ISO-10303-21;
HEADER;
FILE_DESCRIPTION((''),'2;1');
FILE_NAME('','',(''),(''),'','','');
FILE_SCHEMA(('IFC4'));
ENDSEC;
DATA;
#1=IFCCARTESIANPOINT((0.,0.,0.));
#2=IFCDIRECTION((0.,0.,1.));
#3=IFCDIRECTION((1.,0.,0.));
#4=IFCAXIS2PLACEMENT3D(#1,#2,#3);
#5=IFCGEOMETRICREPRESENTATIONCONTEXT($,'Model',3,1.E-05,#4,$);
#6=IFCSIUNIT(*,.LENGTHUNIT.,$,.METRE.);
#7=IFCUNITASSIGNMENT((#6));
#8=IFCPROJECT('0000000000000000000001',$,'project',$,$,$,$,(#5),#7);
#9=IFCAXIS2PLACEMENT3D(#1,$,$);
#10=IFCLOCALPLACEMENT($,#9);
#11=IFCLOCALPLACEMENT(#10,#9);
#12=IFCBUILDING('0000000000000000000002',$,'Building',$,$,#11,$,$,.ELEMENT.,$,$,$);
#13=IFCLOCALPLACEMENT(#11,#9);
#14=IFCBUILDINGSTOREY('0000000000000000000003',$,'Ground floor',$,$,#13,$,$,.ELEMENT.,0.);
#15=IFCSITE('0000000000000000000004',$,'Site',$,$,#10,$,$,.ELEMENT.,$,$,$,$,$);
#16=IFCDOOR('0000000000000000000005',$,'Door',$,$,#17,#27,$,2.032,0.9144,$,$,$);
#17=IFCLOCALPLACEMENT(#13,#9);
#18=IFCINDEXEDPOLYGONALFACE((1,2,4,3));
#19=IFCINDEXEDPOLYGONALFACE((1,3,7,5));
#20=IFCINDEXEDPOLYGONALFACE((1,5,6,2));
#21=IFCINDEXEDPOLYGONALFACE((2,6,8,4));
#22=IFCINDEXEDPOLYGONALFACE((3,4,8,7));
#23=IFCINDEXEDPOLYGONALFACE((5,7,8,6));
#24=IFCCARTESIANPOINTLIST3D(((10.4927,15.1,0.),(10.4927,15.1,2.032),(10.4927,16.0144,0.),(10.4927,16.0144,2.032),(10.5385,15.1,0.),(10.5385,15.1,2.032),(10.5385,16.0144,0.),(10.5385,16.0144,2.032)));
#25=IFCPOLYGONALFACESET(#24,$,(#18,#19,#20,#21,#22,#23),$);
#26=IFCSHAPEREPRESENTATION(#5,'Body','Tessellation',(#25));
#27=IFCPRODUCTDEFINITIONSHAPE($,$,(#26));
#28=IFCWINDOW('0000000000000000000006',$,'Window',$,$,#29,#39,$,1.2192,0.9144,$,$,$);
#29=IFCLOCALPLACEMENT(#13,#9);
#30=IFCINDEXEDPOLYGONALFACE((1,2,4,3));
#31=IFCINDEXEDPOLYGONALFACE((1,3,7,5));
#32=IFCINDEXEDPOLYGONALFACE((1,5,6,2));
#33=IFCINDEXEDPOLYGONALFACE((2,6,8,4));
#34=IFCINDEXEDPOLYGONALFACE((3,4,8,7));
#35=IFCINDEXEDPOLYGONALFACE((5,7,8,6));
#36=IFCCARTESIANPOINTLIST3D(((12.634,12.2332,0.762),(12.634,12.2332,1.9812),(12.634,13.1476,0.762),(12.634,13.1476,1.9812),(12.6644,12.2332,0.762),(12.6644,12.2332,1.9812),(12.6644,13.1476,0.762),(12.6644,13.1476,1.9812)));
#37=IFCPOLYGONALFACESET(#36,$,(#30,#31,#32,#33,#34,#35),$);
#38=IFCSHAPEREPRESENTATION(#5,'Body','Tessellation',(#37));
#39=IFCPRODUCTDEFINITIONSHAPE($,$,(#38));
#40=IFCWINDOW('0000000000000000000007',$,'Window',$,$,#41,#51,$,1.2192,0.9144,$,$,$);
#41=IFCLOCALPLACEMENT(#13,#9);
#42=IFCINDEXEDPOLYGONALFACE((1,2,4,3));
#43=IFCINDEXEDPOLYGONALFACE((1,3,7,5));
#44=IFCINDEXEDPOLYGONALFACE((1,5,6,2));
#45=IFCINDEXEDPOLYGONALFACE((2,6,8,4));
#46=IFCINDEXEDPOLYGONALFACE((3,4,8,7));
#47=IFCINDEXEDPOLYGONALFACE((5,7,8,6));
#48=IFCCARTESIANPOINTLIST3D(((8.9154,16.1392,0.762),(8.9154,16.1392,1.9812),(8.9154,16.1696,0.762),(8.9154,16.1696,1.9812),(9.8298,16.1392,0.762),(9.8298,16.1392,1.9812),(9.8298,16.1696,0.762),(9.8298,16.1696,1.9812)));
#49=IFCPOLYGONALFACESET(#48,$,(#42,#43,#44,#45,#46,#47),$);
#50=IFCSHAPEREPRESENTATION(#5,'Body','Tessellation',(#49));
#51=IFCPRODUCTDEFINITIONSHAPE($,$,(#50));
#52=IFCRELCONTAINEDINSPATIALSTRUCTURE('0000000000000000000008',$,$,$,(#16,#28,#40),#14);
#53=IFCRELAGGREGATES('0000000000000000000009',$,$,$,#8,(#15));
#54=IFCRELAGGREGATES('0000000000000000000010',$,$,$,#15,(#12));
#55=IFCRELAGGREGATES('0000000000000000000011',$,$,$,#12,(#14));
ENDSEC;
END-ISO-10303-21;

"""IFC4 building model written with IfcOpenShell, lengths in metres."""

from ifc_helpers import new_model, si_unit, frame, origin, origin_with_axes, origin_2d, place, context, project, spatial, rectangle, extrude, element, save


model = new_model("IFC4")

# Units and contexts
model_context = context("Model", 3, precision=1e-05, world=origin_with_axes())
ifc_project = project(units=[si_unit("LENGTHUNIT", "METRE")], contexts=[model_context])

# Site, building, storey
site_placement = place(None, origin())
site = spatial("IfcSite", under=ifc_project, at=site_placement, Name="Site", CompositionType="ELEMENT")
building_placement = place(site_placement, origin())
building = spatial("IfcBuilding", under=site, at=building_placement, Name="Building", CompositionType="ELEMENT")
storey_placement = place(building_placement, origin())
storey = spatial("IfcBuildingStorey", under=building, at=storey_placement, Name="Ground floor", CompositionType="ELEMENT", Elevation=0.0)

# Door
for number, where, x_axis, name in (
    (1, (10.5156, 15.5572, 0.0), (0.0, 1.0, 0.0), "Door"),
):
    element("IfcDoor", number, at=place(storey_placement, frame(where, x_axis=x_axis)), inside=storey, Name=name, OverallHeight=2.032, OverallWidth=0.9144, context=model_context, shape_type="SweptSolid", body=[
        extrude(rectangle(XDim=0.9144, YDim=0.0457, at=origin_2d()), origin(), (0.0, 0.0, 1.0), 2.032),
    ])

# Windows
for number, where, x_axis, name in (
    (2, (12.6492, 12.6904, 0.762), (0.0, 1.0, 0.0), "Window"),
    (3, (9.3726, 16.1544, 0.762), (1.0, 0.0, 0.0), "Window"),
):
    element("IfcWindow", number, at=place(storey_placement, frame(where, x_axis=x_axis)), inside=storey, Name=name, OverallHeight=1.2192, OverallWidth=0.9144, context=model_context, shape_type="SweptSolid", body=[
        extrude(rectangle(XDim=0.9144, YDim=0.0305, at=origin_2d()), origin(), (0.0, 0.0, 1.0), 1.2192),
    ])

save(model, "model.ifc")
